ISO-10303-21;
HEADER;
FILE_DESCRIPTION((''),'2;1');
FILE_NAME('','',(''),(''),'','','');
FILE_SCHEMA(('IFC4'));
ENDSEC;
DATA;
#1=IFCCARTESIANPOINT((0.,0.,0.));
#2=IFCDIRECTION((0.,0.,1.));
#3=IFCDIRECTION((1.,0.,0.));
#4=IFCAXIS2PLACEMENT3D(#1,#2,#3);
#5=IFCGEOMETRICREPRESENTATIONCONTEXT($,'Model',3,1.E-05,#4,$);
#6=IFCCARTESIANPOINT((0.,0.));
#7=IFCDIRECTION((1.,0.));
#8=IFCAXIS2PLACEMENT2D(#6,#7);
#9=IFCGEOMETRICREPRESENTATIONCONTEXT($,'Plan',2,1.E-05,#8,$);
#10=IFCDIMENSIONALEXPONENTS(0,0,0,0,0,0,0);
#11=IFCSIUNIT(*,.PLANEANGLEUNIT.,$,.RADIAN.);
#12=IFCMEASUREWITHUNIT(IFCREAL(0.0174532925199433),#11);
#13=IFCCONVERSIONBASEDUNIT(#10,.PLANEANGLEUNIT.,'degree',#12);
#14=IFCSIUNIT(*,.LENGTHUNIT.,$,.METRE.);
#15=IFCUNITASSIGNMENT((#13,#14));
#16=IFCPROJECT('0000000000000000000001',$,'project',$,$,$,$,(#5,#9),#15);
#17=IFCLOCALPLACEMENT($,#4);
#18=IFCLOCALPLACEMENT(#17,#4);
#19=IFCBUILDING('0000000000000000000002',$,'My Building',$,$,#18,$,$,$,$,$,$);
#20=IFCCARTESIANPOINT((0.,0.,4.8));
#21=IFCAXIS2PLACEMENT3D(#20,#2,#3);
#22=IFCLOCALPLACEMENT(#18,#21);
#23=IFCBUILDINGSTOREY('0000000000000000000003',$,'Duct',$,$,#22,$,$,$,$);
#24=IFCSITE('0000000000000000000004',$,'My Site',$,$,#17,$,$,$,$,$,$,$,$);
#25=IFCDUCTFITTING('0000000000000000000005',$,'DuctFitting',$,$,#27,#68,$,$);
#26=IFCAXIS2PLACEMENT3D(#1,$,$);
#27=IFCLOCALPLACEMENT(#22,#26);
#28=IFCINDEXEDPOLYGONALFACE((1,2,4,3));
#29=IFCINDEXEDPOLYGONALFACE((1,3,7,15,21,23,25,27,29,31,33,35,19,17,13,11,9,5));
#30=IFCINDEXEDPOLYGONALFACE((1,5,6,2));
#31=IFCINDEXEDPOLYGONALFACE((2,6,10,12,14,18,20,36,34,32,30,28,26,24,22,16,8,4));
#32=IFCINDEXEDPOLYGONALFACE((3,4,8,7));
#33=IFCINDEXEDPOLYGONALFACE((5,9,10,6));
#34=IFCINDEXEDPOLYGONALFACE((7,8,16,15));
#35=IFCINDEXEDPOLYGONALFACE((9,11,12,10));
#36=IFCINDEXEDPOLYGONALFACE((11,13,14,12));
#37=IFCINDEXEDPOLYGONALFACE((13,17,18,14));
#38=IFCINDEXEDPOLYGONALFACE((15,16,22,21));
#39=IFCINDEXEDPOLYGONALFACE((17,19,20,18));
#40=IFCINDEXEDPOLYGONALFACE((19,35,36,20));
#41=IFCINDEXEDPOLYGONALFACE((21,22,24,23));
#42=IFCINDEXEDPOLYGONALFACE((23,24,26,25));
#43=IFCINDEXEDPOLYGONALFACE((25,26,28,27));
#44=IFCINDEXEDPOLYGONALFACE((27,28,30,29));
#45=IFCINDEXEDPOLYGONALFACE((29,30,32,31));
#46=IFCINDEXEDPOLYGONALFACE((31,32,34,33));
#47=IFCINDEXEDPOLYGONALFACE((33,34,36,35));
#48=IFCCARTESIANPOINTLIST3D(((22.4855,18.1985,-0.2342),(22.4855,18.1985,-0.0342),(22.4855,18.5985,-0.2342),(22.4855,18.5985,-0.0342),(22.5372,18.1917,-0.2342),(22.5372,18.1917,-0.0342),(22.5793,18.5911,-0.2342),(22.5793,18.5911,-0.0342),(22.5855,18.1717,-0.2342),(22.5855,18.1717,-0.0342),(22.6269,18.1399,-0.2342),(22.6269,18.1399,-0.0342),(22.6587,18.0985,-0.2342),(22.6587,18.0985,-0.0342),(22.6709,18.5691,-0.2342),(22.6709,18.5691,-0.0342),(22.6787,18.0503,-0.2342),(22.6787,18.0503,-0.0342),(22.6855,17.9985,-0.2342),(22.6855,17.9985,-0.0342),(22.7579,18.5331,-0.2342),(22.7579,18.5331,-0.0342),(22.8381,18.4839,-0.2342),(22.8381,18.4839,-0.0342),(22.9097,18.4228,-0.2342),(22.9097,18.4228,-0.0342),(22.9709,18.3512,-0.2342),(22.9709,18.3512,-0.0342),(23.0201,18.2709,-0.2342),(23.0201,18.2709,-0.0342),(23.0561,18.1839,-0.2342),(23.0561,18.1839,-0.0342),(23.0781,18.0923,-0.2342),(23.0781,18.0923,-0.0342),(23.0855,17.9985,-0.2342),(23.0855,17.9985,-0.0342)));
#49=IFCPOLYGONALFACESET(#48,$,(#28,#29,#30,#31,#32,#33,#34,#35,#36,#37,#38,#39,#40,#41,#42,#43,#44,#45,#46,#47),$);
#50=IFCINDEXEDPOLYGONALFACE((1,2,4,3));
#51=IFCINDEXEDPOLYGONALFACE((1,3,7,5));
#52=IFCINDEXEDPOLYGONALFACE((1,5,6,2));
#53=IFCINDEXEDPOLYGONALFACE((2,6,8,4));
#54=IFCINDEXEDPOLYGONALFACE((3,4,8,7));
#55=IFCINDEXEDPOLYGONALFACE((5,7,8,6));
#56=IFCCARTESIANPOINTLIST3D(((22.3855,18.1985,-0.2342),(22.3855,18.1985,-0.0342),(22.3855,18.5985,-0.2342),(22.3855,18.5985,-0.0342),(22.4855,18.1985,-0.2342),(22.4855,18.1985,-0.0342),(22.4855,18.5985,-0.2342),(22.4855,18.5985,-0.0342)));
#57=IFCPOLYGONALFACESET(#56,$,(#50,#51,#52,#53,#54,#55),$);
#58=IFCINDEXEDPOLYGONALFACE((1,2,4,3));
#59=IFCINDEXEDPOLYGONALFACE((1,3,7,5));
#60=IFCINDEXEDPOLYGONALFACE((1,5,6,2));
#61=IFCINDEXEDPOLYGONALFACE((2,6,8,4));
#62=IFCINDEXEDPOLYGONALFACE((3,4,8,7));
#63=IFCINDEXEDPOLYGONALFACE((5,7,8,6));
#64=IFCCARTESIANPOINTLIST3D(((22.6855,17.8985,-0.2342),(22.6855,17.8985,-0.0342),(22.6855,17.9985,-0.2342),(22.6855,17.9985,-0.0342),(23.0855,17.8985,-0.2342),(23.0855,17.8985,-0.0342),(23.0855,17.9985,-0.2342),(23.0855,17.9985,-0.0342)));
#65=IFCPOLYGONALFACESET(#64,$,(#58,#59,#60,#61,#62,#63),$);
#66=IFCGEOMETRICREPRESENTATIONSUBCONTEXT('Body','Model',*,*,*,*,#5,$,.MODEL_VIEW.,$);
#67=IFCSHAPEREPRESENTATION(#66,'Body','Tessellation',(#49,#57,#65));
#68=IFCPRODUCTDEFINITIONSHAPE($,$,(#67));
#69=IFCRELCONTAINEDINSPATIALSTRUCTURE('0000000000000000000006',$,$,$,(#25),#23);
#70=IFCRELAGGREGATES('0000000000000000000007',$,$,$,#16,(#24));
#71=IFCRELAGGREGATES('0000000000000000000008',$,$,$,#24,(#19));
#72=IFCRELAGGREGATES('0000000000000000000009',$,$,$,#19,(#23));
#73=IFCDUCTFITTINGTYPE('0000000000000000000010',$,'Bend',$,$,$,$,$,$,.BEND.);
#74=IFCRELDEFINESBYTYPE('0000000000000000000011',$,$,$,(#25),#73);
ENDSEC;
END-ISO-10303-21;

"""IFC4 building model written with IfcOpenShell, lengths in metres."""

from ifc_helpers import new_model, entity, si_unit, converted_unit, frame, origin_with_axes, origin_2d_with_axis, place, context, subcontext, project, spatial, line, arc, indexed_curve, rectangle, outline, extrude, source, transform, mapped, type_object, type_shapes, element, save


model = new_model("IFC4")

# Units and contexts
model_context = context("Model", 3, precision=1e-05, world=origin_with_axes())
plan_context = context("Plan", 2, precision=1e-05, world=origin_2d_with_axis())
body_context = subcontext(model_context, "Body", "Model", "MODEL_VIEW")
ifc_project = project(units=[converted_unit("PLANEANGLEUNIT", "degree", entity("IfcReal", 0.0174532925199433), si_unit("PLANEANGLEUNIT", "RADIAN"), dimensions=[0, 0, 0, 0, 0, 0, 0]), si_unit("LENGTHUNIT", "METRE")], contexts=[model_context, plan_context])

# Site, building, storey
site_placement = place(None, origin_with_axes())
site = spatial("IfcSite", under=ifc_project, at=site_placement, Name="My Site")
building_placement = place(site_placement, origin_with_axes())
building = spatial("IfcBuilding", under=site, at=building_placement, Name="My Building")
storey_placement = place(building_placement, frame((0.0, 0.0, 4.8), z_axis=(0.0, 0.0, 1.0), x_axis=(1.0, 0.0, 0.0)))
storey = spatial("IfcBuildingStorey", under=building, at=storey_placement, Name="Duct")

# Duct fitting
duct_fitting_type_1 = type_object("IfcDuctFittingType", Name="Bend", PredefinedType="BEND")
shared_shape = source(origin_with_axes(), body_context, "Body", "SweptSolid", [
    extrude(outline(indexed_curve([(-0.2, 0.0), (-0.2586, -0.1414), (-0.4, -0.2), (-0.4, -0.6), (0.0243, -0.4243), (0.2, 0.0)], segments=[arc(1, 2, 3), line(3, 4), arc(4, 5, 6), line(6, 1)])), frame((0.0, -0.1, -0.1), z_axis=(0.0, -1.0, 0.0), x_axis=(1.0, 0.0, 0.0)), (0.0, 0.0, -1.0), 0.2),
    extrude(rectangle(XDim=0.4, YDim=0.2), origin_with_axes(), (0.0, 0.0, -1.0), 0.1),
    extrude(rectangle(XDim=0.4, YDim=0.2), frame((-0.4, 0.0, -0.5), z_axis=(-1.0, 0.0, 0.0), x_axis=(0.0, 0.0, -1.0)), (0.0, 0.0, 1.0), 0.1),
])
type_shapes(duct_fitting_type_1, [shared_shape])
for number, where, z_axis, x_axis, name in (
    (1, (22.3855, 18.3985, -0.1342), (-1.0, 0.0, 0.0), (0.0, 1.0, 0.0), "DuctFitting"),
):
    element("IfcDuctFitting", number, at=place(storey_placement, frame(where, z_axis=z_axis, x_axis=x_axis)), inside=storey, type_object=duct_fitting_type_1, Name=name, context=body_context, shape_type="MappedRepresentation", body=[
        mapped(shared_shape, transform((0.0, 0.0, 0.0), x_axis=(1.0, 0.0, 0.0), y_axis=(0.0, 1.0, 0.0), z_axis=(0.0, 0.0, 1.0), scale=1.0)),
    ])

save(model, "model.ifc")
